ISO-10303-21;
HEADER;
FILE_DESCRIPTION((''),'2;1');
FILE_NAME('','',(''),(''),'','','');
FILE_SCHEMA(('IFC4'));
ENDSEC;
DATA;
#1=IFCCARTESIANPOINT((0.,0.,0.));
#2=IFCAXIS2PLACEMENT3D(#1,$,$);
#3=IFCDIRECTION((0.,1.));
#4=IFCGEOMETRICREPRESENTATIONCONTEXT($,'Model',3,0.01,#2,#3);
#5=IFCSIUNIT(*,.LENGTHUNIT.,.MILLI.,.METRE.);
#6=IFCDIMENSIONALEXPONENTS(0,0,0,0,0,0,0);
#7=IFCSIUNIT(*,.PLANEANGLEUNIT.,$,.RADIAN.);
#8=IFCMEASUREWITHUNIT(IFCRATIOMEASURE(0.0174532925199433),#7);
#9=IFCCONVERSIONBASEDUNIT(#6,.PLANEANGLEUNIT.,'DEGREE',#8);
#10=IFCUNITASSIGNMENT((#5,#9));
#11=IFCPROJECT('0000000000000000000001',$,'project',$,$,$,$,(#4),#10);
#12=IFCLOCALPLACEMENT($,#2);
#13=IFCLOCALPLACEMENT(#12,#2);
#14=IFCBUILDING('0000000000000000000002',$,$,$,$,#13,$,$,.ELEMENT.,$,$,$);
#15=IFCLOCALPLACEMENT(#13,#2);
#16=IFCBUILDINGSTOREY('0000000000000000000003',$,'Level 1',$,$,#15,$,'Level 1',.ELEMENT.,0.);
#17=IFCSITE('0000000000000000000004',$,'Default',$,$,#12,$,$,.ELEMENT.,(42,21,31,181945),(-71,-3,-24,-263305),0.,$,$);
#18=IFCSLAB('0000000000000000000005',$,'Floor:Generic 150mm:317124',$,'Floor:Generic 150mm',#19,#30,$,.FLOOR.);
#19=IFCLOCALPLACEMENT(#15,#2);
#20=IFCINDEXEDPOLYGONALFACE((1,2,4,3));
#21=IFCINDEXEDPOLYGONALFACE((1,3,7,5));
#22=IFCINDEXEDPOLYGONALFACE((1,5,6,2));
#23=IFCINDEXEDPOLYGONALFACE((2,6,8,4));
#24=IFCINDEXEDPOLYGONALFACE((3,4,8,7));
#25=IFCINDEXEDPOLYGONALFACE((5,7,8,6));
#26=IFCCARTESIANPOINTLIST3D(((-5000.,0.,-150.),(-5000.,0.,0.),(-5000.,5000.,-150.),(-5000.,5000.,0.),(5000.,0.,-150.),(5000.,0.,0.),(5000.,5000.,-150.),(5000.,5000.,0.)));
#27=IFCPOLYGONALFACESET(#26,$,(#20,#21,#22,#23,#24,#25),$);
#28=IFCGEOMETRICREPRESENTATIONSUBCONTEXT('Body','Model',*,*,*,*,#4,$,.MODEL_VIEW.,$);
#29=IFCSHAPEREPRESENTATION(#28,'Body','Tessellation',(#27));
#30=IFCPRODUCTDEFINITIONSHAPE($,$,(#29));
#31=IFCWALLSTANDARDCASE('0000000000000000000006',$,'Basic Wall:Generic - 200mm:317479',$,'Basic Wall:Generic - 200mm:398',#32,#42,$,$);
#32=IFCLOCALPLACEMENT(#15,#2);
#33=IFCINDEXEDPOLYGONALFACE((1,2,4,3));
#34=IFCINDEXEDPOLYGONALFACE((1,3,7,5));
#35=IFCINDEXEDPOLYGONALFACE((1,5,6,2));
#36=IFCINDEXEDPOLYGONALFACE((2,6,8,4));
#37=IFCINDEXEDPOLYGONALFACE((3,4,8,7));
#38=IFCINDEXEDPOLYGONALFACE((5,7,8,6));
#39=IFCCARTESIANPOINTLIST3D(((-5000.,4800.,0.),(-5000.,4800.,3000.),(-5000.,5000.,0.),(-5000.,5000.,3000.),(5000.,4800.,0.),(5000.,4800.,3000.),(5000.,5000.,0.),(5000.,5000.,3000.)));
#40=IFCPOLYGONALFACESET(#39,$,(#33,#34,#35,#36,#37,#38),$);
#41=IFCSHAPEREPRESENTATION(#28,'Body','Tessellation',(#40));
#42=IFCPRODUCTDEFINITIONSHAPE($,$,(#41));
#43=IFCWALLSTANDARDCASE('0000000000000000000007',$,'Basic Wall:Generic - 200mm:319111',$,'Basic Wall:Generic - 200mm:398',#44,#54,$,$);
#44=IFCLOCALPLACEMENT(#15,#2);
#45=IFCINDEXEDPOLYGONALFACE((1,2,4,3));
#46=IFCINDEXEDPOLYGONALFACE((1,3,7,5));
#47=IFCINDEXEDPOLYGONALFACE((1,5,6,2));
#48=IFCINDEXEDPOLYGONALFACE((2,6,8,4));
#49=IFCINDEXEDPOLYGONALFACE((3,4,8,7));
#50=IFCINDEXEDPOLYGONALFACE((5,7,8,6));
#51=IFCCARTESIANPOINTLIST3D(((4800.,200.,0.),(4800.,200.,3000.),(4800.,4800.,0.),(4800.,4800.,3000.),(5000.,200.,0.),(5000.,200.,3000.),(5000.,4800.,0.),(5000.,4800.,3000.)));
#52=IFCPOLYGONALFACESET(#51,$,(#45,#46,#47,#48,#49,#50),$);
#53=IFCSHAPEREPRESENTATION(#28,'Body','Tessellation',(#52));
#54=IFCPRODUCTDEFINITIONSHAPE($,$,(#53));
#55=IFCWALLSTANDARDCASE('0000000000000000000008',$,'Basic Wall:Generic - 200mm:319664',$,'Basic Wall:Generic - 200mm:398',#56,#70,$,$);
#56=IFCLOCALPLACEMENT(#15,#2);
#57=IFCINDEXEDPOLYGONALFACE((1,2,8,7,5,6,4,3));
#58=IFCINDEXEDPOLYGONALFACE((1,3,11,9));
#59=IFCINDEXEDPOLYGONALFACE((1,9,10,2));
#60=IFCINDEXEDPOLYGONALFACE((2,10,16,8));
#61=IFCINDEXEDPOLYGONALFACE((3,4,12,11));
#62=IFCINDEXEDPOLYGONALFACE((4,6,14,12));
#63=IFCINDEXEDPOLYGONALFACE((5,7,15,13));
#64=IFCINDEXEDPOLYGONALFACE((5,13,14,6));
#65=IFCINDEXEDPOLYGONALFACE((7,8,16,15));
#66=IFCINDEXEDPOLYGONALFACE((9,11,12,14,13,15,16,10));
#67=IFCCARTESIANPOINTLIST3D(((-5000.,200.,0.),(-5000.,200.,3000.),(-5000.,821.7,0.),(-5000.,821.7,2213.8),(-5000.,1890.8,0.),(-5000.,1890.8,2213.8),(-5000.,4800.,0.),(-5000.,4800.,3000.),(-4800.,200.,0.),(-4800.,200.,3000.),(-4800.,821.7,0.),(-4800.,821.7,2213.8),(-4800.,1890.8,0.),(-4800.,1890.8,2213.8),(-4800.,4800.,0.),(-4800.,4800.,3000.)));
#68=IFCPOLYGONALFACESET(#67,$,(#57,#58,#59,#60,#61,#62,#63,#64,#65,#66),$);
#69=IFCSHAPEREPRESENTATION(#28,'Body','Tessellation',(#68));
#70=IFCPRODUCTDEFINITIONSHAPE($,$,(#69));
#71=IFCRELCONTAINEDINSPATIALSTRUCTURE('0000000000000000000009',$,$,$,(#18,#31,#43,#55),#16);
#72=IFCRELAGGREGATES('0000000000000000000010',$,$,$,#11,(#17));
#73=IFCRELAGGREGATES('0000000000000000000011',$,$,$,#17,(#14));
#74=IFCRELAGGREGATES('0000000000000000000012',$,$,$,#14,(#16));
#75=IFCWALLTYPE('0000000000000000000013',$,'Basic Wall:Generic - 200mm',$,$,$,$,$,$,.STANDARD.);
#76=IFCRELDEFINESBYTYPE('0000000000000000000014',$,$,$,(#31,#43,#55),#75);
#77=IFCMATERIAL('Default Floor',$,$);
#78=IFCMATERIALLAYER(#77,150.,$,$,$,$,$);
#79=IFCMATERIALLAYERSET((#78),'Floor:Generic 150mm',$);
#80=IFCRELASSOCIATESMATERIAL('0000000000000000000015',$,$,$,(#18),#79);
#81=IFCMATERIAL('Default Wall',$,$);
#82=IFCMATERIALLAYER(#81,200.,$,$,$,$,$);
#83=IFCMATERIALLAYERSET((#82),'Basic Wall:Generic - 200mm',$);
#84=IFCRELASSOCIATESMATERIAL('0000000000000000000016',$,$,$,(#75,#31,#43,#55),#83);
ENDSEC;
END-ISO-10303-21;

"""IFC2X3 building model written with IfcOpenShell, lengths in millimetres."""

from ifc_helpers import new_model, entity, si_unit, converted_unit, direction, frame, frame_2d, origin, origin_2d_with_axis, place, context, subcontext, project, spatial, rectangle, extrude, material, layer, layer_set, layer_usage, type_object, element, save


model = new_model("IFC2X3")

# Units and contexts
model_context = context("Model", 3, precision=0.01, world=origin(), true_north=direction((0.0, 1.0)))
body_context = subcontext(model_context, "Body", "Model", "MODEL_VIEW")
ifc_project = project(units=[si_unit("LENGTHUNIT", "METRE", prefix="MILLI"), converted_unit("PLANEANGLEUNIT", "DEGREE", entity("IfcRatioMeasure", 0.0174532925199433), si_unit("PLANEANGLEUNIT", "RADIAN"), dimensions=[0, 0, 0, 0, 0, 0, 0])], contexts=[model_context])

# Site, building, storey
site_placement = place(None, origin())
site = spatial("IfcSite", under=ifc_project, at=site_placement, Name="Default", CompositionType="ELEMENT", RefLatitude=(42, 21, 31, 181945), RefLongitude=(-71, -3, -24, -263305), RefElevation=0.0)
building_placement = place(site_placement, origin())
building = spatial("IfcBuilding", under=site, at=building_placement, CompositionType="ELEMENT")
storey_placement = place(building_placement, origin())
storey = spatial("IfcBuildingStorey", under=building, at=storey_placement, Name="Level 1", LongName="Level 1", CompositionType="ELEMENT", Elevation=0.0)

# Slab
ifc_material_1 = material(Name="Default Floor")
ifc_layer_1 = layer(ifc_material_1, 150.0)
ifc_layer_set_1 = layer_set([ifc_layer_1], Name="Floor:Generic 150mm")
ifc_layer_usage_1 = layer_usage(ifc_layer_set_1, "AXIS3", "POSITIVE", 0.0)
slab_placement = place(storey_placement, origin())
element("IfcSlab", 1, at=slab_placement, inside=storey, material=ifc_layer_usage_1, Name="Floor:Generic 150mm:317124", ObjectType="Floor:Generic 150mm", PredefinedType="FLOOR", context=body_context, shape_type="SweptSolid", body=[
    extrude(rectangle(XDim=5000.0, YDim=10000.0, at=origin_2d_with_axis()), frame((0.0, 2500.0, 0.0), z_axis=(0.0, 0.0, -1.0), x_axis=(0.0, 1.0, 0.0)), (0.0, 0.0, 1.0), 150.0),
])

# Wall
ifc_material_2 = material(Name="Default Wall")
ifc_layer_2 = layer(ifc_material_2, 200.0)
ifc_layer_set_2 = layer_set([ifc_layer_2], Name="Basic Wall:Generic - 200mm")
ifc_layer_usage_2 = layer_usage(ifc_layer_set_2, "AXIS2", "NEGATIVE", 100.0)
wall_type = type_object("IfcWallType", Name="Basic Wall:Generic - 200mm", PredefinedType="STANDARD", material=ifc_layer_set_2)
wall_1_placement = place(storey_placement, frame((-5000.0, 4900.0, 0.0)))
element("IfcWallStandardCase", 2, at=wall_1_placement, inside=storey, type_object=wall_type, material=ifc_layer_usage_2, Name="Basic Wall:Generic - 200mm:317479", ObjectType="Basic Wall:Generic - 200mm:398", context=body_context, shape_type="SweptSolid", body=[
    extrude(rectangle(XDim=10000.0, YDim=200.0, at=frame_2d((5000.0, 0.0), x_axis=(-1.0, 0.0))), origin(), (0.0, 0.0, 1.0), 3000.0),
])

# Wall
ifc_layer_usage_3 = layer_usage(ifc_layer_set_2, "AXIS2", "NEGATIVE", 100.0)
wall_2_placement = place(storey_placement, frame((4900.0, 200.0, 0.0), z_axis=(0.0, 0.0, 1.0), x_axis=(0.0, 1.0, 0.0)))
element("IfcWallStandardCase", 3, at=wall_2_placement, inside=storey, type_object=wall_type, material=ifc_layer_usage_3, Name="Basic Wall:Generic - 200mm:319111", ObjectType="Basic Wall:Generic - 200mm:398", context=body_context, shape_type="SweptSolid", body=[
    extrude(rectangle(XDim=4600.0, YDim=200.0, at=frame_2d((2300.0, 0.0), x_axis=(-1.0, 0.0))), origin(), (0.0, 0.0, 1.0), 3000.0),
])

# Wall, opening
ifc_layer_usage_4 = layer_usage(ifc_layer_set_2, "AXIS2", "NEGATIVE", 100.0)
wall_3_placement = place(storey_placement, frame((-4900.0, 4800.0, 0.0), z_axis=(0.0, 0.0, 1.0), x_axis=(0.0, -1.0, 0.0)))
wall_3 = element("IfcWallStandardCase", 4, at=wall_3_placement, inside=storey, type_object=wall_type, material=ifc_layer_usage_4, Name="Basic Wall:Generic - 200mm:319664", ObjectType="Basic Wall:Generic - 200mm:398", context=body_context, shape_type="SweptSolid", body=[
    extrude(rectangle(XDim=4600.0, YDim=200.0, at=frame_2d((2300.0, 0.0), x_axis=(-1.0, 0.0))), origin(), (0.0, 0.0, 1.0), 3000.0),
])
opening_1_placement = place(wall_3_placement, origin())
element("IfcOpeningElement", 5, at=opening_1_placement, cuts=wall_3, ObjectType="Opening", context=body_context, shape_type="SweptSolid", body=[
    extrude(rectangle(XDim=2213.8, YDim=1069.1, at=origin_2d_with_axis()), frame((3443.8, -100.0, 1106.9), z_axis=(0.0, 1.0, 0.0), x_axis=(0.0, 0.0, -1.0)), (0.0, 0.0, 1.0), 200.0),
])

save(model, "model.ifc")
